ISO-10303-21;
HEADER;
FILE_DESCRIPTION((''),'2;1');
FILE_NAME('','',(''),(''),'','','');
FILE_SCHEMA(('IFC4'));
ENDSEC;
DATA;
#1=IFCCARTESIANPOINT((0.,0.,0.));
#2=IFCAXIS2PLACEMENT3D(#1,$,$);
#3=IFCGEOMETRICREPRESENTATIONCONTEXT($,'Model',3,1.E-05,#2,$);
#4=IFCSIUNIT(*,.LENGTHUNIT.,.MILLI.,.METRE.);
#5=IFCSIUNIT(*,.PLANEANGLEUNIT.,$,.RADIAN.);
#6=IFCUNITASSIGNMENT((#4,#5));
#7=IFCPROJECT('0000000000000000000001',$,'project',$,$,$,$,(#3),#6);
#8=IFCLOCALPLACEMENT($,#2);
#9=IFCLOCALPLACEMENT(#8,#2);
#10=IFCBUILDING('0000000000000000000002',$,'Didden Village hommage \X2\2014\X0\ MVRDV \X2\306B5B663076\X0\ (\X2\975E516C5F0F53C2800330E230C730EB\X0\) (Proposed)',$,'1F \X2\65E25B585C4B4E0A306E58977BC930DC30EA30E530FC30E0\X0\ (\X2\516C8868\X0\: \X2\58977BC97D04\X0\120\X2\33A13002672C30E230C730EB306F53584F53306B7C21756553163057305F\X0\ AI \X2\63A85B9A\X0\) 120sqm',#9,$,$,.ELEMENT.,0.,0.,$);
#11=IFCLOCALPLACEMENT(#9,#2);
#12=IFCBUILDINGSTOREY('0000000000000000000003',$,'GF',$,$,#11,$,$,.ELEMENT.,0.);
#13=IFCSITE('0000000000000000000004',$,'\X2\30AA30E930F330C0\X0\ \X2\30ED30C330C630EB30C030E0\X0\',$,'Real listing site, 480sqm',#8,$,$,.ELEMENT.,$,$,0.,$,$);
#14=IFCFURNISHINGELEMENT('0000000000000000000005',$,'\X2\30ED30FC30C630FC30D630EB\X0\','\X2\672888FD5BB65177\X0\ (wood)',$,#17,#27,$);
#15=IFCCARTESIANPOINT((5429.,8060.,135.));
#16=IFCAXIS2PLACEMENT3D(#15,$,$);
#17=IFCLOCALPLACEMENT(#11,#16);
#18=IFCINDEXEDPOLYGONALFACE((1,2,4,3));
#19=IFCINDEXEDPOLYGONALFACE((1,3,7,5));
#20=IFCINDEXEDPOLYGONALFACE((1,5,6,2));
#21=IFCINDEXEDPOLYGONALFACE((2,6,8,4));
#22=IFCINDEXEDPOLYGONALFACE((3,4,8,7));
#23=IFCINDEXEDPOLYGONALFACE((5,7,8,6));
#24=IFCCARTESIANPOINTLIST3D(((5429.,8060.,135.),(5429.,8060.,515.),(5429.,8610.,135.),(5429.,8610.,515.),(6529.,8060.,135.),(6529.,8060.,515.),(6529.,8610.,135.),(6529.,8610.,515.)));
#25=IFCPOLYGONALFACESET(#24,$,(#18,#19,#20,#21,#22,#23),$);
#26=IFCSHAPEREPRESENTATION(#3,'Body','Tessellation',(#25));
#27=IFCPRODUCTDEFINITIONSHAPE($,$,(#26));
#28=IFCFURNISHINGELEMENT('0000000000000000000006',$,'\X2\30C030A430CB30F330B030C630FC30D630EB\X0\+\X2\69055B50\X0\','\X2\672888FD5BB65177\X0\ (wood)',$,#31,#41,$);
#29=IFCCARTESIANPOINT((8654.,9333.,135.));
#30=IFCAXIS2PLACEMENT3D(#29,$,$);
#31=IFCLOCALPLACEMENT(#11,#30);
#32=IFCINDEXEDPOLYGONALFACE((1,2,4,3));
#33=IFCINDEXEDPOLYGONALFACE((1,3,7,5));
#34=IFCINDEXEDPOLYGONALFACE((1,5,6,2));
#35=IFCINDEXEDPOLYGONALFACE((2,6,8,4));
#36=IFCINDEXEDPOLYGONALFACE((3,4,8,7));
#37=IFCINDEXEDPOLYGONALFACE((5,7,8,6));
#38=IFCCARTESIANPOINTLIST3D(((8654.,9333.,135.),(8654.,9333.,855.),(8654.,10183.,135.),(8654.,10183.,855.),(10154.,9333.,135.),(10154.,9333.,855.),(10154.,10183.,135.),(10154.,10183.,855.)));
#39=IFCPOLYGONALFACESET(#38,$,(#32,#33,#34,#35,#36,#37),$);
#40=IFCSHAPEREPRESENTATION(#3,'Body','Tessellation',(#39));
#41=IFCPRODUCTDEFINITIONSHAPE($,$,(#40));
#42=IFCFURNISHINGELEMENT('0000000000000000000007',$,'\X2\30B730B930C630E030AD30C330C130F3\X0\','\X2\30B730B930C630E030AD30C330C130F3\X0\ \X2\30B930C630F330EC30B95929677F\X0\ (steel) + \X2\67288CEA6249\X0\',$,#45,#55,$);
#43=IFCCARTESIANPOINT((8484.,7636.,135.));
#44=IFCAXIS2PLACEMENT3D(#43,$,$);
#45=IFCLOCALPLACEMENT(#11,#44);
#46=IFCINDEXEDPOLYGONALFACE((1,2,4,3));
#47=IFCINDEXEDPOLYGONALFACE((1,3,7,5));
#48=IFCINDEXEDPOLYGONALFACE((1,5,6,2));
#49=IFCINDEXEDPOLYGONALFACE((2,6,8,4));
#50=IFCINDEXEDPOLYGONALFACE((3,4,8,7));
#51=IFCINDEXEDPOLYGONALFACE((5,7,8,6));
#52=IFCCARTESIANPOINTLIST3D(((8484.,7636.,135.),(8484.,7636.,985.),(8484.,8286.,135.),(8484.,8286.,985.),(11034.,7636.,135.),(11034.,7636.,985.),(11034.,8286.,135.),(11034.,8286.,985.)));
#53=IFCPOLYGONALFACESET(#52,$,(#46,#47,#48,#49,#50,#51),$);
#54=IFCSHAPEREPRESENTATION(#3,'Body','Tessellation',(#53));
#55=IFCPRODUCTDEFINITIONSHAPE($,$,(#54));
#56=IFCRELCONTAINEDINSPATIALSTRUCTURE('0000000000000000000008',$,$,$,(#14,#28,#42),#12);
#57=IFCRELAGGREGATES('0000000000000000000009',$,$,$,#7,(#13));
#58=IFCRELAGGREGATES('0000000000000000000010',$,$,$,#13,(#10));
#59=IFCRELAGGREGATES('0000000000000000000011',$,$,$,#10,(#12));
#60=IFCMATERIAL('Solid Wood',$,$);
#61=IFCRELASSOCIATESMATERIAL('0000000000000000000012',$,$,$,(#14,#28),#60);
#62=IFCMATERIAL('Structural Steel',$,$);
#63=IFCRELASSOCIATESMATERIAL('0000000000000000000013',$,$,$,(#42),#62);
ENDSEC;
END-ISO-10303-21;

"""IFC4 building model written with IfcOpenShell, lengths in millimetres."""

from ifc_helpers import new_model, si_unit, frame, frame_2d, origin, place, context, project, spatial, rectangle, extrude, material, element, save


model = new_model("IFC4")

# Units and contexts
model_context = context("Model", 3, precision=1e-05, world=origin())
ifc_project = project(units=[si_unit("LENGTHUNIT", "METRE", prefix="MILLI"), si_unit("PLANEANGLEUNIT", "RADIAN")], contexts=[model_context])

# Site, building, storey
site_placement = place(None, origin())
site = spatial("IfcSite", under=ifc_project, at=site_placement, Name="オランダ ロッテルダム", ObjectType="Real listing site, 480sqm", CompositionType="ELEMENT", RefElevation=0.0)
building_placement = place(site_placement, origin())
building = spatial("IfcBuilding", under=site, at=building_placement, Name="Didden Village hommage — MVRDV に学ぶ (非公式参考モデル) (Proposed)", ObjectType="1F 既存屋上の増築ボリューム (公表: 増築約120㎡。本モデルは単体に簡略化した AI 推定) 120sqm", CompositionType="ELEMENT", ElevationOfRefHeight=0.0, ElevationOfTerrain=0.0)
storey_placement = place(building_placement, origin())
storey = spatial("IfcBuildingStorey", under=building, at=storey_placement, Name="GF", CompositionType="ELEMENT", Elevation=0.0)

# Shared definitions
ifc_material_1 = material(Name="Solid Wood")

# Shared definitions
ifc_material_2 = material(Name="Structural Steel")

# Furnishing elements
furnishing_1_placement = place(storey_placement, frame((5429.0, 8060.0, 135.0)))
element("IfcFurnishingElement", 1, at=furnishing_1_placement, inside=storey, material=ifc_material_1, Name="ローテーブル", Description="木製家具 (wood)", context=model_context, shape_type="SweptSolid", body=[
    extrude(rectangle(XDim=1100.0, YDim=550.0, at=frame_2d((550.0, 275.0))), frame((5429.0, 8060.0, 135.0)), (0.0, 0.0, 1.0), 380.0),
])
furnishing_2_placement = place(storey_placement, frame((8654.0, 9333.0, 135.0)))
element("IfcFurnishingElement", 2, at=furnishing_2_placement, inside=storey, material=ifc_material_1, Name="ダイニングテーブル+椅子", Description="木製家具 (wood)", context=model_context, shape_type="SweptSolid", body=[
    extrude(rectangle(XDim=1500.0, YDim=850.0, at=frame_2d((750.0, 425.0))), frame((8654.0, 9333.0, 135.0)), (0.0, 0.0, 1.0), 720.0),
])
furnishing_3_placement = place(storey_placement, frame((8484.0, 7636.0, 135.0)))
element("IfcFurnishingElement", 3, at=furnishing_3_placement, inside=storey, material=ifc_material_2, Name="システムキッチン", Description="システムキッチン ステンレス天板 (steel) + 木質扉", context=model_context, shape_type="SweptSolid", body=[
    extrude(rectangle(XDim=2550.0, YDim=650.0, at=frame_2d((1275.0, 325.0))), frame((8484.0, 7636.0, 135.0)), (0.0, 0.0, 1.0), 850.0),
])

save(model, "model.ifc")
